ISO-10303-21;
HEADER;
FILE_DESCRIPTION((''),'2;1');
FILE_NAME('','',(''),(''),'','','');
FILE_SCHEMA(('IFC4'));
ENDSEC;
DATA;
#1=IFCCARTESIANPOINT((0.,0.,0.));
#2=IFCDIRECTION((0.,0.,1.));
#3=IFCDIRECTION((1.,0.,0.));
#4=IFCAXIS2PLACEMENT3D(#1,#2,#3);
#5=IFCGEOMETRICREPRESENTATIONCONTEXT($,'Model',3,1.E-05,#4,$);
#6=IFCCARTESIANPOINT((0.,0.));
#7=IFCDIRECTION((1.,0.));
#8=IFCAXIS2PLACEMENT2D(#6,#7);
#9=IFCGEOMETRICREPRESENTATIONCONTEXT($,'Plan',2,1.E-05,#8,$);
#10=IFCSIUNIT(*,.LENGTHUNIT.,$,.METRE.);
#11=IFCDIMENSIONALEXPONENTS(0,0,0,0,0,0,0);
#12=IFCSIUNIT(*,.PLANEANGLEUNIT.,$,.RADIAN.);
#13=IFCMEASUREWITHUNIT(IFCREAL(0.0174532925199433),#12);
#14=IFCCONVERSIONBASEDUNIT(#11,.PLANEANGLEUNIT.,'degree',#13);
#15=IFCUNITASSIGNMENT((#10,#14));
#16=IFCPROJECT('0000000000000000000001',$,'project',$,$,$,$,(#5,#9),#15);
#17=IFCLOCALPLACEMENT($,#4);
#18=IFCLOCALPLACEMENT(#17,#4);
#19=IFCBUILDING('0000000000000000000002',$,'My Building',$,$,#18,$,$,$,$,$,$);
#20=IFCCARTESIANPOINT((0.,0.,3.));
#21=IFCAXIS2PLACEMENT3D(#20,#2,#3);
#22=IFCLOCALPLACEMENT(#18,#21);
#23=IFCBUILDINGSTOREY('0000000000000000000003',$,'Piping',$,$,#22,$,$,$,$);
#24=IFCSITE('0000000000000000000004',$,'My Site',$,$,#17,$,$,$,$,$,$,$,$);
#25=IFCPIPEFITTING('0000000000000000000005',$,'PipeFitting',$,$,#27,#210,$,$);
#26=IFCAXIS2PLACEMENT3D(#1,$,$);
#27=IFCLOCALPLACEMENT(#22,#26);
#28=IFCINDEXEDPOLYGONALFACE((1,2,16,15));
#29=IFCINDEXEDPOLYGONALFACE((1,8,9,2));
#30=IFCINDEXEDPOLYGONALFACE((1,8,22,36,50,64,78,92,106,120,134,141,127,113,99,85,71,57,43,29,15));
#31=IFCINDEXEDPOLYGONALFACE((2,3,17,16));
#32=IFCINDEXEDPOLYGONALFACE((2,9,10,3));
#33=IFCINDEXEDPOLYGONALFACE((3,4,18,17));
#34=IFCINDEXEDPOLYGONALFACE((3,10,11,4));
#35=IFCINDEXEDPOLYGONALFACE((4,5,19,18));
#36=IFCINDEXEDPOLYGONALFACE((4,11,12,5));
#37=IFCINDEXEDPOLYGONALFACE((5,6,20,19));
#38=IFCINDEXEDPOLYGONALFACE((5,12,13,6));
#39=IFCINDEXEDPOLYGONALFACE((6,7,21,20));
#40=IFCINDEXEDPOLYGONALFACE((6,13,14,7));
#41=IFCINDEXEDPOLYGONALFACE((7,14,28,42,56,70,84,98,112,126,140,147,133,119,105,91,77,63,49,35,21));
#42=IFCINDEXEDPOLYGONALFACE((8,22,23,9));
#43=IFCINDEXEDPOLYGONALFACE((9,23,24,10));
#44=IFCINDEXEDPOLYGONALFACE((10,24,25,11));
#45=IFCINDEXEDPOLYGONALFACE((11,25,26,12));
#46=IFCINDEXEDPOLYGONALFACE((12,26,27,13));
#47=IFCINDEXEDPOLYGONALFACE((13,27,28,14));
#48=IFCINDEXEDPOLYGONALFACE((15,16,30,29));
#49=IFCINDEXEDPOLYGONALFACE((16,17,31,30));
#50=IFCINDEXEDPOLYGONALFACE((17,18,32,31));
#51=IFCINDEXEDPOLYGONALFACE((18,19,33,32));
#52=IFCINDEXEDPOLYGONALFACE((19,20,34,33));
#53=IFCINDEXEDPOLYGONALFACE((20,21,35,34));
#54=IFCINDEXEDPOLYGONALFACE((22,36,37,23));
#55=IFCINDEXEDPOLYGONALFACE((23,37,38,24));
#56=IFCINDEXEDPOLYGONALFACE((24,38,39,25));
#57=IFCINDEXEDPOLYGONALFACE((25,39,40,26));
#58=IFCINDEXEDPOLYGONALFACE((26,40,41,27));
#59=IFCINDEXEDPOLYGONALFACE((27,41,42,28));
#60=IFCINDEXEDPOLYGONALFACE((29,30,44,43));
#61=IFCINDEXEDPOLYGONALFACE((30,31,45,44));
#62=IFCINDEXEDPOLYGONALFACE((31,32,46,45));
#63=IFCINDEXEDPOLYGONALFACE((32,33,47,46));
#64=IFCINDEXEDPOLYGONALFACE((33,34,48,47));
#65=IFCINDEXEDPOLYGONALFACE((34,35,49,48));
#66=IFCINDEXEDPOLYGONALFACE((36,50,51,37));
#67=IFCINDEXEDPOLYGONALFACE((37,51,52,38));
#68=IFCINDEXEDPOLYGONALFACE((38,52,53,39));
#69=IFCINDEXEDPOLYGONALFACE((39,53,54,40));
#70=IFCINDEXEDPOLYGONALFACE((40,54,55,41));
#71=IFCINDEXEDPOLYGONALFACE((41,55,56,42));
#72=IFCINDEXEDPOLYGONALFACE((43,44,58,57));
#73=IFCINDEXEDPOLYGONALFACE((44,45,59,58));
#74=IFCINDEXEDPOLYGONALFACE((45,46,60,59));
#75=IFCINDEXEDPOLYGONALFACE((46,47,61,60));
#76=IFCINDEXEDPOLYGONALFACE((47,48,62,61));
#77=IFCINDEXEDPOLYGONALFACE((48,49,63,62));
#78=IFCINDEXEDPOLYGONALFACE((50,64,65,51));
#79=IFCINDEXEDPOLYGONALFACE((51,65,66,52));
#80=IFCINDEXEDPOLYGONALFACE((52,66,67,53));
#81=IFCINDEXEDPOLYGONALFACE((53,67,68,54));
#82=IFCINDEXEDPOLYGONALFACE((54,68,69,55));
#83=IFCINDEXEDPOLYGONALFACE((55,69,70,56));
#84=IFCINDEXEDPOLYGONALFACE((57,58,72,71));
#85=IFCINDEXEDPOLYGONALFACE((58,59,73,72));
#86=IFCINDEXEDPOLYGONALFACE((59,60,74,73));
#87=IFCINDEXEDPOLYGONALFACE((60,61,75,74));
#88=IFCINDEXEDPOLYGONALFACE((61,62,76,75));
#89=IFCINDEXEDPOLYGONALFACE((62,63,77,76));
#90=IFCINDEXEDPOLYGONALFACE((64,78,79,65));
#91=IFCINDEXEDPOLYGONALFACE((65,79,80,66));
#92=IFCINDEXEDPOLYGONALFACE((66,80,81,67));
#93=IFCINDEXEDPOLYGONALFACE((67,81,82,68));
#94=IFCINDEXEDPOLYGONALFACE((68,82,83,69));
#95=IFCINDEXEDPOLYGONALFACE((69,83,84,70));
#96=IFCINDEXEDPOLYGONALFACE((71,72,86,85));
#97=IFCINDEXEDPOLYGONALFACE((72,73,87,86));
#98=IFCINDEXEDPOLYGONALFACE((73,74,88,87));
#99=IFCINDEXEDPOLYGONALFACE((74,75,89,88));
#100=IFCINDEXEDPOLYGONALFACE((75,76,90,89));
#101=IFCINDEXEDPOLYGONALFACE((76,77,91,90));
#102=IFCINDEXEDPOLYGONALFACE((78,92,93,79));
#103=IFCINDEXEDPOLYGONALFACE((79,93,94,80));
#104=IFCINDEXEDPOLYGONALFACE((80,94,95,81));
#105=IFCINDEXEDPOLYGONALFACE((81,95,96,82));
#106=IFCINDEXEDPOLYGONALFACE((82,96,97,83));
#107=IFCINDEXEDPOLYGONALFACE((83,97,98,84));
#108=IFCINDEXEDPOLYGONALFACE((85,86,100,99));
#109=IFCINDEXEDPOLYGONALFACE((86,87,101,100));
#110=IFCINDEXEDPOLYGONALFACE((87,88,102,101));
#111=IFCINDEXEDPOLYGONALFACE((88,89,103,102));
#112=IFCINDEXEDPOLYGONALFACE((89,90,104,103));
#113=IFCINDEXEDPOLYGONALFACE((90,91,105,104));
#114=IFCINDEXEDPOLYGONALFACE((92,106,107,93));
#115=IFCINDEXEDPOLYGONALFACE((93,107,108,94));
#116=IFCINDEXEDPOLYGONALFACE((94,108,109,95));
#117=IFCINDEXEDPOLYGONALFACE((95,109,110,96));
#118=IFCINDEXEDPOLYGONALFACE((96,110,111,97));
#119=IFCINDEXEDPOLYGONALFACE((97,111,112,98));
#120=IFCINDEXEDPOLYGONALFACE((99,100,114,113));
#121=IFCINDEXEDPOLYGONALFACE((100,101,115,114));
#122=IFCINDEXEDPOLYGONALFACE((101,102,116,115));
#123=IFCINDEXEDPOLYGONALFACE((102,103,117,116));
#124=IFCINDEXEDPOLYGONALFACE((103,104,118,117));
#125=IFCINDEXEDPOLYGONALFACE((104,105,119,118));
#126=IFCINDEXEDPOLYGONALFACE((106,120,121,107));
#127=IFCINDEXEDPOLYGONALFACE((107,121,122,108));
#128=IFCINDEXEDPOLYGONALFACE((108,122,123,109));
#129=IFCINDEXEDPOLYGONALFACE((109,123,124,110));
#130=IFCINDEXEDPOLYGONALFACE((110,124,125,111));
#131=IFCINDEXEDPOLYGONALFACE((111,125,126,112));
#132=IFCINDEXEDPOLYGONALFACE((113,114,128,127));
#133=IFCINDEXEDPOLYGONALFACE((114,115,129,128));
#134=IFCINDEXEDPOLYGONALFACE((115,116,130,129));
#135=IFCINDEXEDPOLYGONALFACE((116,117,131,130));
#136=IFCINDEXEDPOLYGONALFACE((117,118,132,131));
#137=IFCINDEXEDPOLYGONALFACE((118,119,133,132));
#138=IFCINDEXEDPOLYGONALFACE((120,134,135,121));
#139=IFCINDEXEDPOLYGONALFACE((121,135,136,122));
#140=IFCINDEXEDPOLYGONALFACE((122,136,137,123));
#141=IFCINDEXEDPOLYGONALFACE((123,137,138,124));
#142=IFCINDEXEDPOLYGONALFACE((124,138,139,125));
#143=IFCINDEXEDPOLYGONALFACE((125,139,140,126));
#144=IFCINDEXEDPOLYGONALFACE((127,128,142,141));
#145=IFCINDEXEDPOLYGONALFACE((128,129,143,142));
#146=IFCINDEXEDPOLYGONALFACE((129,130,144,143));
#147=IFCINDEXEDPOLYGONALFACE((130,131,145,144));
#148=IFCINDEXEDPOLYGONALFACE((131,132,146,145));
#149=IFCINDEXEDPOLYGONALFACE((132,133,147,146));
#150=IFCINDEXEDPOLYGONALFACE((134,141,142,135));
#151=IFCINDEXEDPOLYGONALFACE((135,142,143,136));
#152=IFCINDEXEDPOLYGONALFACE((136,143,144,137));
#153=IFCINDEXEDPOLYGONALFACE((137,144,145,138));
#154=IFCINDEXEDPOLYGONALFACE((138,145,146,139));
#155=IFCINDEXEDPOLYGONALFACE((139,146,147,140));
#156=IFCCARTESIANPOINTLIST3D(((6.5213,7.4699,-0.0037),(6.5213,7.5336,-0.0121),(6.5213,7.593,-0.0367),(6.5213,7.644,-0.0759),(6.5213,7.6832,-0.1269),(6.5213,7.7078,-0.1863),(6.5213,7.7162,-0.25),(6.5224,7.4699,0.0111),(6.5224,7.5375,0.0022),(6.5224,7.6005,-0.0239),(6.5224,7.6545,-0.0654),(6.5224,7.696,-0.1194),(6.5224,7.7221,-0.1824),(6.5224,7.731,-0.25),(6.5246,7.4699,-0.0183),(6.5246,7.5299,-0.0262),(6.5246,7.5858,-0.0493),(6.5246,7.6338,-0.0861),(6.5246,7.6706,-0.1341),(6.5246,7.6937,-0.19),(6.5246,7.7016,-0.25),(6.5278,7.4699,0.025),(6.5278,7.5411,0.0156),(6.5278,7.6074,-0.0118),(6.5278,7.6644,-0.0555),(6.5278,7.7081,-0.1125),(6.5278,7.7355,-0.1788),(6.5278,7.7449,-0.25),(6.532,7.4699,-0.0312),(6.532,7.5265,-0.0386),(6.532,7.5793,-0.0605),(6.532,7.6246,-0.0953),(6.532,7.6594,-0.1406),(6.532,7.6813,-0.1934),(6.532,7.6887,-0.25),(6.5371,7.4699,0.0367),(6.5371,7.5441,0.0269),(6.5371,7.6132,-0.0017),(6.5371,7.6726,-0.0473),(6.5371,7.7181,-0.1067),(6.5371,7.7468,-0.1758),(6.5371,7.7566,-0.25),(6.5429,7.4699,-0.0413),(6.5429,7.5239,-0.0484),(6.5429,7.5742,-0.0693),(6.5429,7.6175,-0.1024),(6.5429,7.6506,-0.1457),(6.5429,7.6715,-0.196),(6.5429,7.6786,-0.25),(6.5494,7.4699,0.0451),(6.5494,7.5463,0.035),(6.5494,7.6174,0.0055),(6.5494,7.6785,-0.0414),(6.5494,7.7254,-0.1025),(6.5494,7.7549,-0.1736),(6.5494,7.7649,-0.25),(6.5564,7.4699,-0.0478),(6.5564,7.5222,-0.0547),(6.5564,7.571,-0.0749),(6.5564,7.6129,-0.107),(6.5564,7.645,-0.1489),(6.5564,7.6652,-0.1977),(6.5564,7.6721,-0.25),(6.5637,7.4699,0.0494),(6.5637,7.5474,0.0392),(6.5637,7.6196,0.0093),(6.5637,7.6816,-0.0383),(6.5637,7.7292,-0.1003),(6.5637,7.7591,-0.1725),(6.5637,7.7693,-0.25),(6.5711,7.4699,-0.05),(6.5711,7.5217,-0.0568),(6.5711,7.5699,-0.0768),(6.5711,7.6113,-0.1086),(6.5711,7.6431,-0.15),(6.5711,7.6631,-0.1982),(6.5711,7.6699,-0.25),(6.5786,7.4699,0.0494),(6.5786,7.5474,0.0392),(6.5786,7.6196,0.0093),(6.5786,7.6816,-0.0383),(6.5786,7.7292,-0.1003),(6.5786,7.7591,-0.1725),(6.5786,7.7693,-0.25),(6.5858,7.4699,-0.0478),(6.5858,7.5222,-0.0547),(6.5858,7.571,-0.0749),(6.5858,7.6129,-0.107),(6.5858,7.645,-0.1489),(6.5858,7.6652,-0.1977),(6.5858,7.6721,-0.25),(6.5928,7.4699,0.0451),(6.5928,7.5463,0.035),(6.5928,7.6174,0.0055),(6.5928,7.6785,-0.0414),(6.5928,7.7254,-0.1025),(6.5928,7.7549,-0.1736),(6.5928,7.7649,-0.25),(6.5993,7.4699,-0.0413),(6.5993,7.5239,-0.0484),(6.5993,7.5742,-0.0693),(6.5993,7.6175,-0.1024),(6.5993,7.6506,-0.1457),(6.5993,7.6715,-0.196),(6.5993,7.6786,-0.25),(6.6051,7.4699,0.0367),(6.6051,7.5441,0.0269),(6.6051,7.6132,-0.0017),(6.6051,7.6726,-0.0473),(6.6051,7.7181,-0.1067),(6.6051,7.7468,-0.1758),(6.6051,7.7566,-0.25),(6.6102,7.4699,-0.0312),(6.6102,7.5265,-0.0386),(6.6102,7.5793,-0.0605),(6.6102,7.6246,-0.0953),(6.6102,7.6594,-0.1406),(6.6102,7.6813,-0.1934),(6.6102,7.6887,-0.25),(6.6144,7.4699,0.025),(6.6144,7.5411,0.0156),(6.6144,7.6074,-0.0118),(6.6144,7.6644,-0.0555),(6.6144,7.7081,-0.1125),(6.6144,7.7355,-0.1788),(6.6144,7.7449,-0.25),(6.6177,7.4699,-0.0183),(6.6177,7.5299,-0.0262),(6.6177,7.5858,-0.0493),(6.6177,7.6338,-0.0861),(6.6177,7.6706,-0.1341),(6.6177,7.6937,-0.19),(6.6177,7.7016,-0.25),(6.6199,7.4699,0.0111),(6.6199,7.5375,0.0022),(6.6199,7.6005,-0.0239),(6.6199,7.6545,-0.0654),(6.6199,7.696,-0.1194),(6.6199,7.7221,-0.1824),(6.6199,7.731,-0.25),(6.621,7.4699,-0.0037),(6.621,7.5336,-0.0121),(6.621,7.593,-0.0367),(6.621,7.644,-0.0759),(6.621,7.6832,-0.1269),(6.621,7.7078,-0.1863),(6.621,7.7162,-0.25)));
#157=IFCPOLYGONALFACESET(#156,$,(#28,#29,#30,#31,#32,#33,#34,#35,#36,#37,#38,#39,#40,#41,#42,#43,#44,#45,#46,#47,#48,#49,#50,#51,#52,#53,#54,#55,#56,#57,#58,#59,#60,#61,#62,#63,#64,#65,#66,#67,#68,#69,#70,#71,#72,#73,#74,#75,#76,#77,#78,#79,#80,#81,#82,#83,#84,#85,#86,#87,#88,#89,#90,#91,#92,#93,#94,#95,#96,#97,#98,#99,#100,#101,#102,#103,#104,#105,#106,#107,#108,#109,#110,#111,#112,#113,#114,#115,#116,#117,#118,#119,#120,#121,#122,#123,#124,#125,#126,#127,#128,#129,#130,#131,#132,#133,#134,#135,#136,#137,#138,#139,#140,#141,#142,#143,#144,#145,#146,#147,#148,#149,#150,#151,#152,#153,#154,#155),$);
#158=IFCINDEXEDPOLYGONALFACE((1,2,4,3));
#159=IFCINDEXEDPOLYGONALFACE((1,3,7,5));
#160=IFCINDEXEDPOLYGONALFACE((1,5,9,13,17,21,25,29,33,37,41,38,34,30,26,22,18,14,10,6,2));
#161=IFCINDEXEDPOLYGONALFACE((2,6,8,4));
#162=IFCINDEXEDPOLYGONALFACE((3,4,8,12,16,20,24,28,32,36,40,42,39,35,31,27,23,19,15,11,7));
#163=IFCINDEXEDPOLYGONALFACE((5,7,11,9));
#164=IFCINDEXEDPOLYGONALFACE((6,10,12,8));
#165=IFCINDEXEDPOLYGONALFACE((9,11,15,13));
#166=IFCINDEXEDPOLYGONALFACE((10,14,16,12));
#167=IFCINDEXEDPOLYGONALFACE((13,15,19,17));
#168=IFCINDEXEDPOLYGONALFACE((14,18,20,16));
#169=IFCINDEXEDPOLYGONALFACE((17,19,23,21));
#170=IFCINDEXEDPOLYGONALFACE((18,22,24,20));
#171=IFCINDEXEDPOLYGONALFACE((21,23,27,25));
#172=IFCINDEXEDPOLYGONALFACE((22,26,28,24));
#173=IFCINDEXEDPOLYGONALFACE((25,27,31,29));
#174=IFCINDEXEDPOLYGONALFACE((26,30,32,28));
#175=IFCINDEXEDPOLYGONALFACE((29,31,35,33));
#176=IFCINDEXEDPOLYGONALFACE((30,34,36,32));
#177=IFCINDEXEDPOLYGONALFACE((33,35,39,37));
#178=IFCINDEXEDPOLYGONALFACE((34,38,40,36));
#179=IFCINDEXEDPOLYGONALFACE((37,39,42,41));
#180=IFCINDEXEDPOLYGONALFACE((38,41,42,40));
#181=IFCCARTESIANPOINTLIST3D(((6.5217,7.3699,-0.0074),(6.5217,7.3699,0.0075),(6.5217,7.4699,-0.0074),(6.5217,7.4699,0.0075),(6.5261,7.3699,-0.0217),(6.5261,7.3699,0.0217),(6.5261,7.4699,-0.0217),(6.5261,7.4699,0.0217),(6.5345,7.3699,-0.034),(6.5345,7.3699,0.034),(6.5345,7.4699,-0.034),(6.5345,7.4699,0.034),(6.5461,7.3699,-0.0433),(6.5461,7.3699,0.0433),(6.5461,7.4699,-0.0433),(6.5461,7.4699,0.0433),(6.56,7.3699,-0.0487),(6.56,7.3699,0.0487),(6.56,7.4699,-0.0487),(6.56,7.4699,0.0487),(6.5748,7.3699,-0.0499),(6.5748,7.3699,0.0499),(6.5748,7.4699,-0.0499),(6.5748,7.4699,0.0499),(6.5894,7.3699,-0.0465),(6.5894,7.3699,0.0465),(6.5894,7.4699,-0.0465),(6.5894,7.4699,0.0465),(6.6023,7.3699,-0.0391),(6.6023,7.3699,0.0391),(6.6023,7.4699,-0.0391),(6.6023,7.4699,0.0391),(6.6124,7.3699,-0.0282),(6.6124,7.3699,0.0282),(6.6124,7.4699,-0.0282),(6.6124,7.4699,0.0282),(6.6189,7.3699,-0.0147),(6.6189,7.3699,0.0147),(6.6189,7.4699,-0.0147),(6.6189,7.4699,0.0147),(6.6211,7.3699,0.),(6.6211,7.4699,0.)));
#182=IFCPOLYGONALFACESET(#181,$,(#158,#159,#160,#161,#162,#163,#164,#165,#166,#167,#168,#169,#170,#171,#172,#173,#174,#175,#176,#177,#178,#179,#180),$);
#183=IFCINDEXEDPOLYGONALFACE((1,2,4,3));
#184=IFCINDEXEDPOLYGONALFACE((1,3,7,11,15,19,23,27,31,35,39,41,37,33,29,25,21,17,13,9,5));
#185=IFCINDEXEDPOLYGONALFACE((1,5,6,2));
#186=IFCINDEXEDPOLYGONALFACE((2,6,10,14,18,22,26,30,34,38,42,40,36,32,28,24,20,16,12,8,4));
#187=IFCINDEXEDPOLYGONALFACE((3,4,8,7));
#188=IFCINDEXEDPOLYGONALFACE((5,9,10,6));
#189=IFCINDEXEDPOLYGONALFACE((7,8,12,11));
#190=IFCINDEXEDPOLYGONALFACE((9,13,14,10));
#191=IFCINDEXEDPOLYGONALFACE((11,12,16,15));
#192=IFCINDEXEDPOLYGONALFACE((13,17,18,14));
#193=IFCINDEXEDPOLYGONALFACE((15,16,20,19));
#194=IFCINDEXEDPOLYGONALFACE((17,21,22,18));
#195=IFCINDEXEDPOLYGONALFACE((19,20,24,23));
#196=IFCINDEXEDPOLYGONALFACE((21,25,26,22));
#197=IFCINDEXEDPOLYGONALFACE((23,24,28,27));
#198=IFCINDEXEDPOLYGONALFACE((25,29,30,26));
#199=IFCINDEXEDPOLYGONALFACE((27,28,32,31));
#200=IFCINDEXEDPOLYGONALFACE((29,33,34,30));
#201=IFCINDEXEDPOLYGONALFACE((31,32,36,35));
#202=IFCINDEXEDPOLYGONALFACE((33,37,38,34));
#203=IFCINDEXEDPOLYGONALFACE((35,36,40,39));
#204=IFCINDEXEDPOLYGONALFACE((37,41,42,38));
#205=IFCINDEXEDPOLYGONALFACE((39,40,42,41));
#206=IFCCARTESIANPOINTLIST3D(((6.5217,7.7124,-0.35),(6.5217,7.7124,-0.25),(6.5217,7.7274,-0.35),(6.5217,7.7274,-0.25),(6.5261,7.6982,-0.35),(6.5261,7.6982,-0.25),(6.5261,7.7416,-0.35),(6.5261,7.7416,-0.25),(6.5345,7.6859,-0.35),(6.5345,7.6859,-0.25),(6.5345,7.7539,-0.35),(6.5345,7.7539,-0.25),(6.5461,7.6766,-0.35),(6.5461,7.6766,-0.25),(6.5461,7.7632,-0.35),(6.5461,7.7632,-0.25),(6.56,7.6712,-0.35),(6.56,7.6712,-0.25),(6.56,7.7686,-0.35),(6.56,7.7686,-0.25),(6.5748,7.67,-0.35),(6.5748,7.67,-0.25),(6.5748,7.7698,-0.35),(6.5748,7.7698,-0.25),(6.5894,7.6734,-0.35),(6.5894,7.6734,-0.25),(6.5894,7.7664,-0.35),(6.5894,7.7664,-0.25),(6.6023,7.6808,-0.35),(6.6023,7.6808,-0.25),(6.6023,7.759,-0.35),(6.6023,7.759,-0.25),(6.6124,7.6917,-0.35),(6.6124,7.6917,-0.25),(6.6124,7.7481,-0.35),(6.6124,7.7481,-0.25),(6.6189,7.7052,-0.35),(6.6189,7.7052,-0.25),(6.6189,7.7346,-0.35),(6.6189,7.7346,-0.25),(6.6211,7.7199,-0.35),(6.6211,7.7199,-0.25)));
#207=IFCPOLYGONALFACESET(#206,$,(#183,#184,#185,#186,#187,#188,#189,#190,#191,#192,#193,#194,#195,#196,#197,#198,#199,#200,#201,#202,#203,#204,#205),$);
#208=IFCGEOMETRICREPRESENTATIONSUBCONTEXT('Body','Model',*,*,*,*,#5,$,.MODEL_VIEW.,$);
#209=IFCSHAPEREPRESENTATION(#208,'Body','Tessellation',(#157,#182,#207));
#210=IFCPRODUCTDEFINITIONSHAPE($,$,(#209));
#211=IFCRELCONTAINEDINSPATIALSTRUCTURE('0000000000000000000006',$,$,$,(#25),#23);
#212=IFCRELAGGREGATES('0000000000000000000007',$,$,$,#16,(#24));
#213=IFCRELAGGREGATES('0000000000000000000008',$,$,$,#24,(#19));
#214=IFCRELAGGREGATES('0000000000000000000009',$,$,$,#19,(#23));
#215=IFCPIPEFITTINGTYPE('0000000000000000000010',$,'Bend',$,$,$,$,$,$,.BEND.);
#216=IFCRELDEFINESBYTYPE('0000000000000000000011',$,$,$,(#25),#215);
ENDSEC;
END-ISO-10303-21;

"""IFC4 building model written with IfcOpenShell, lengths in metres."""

from ifc_helpers import new_model, entity, si_unit, converted_unit, frame, origin_with_axes, origin_2d_with_axis, place, context, subcontext, project, spatial, circle, extrude, source, transform, mapped, type_object, type_shapes, element, save


model = new_model("IFC4")

# Units and contexts
model_context = context("Model", 3, precision=1e-05, world=origin_with_axes())
plan_context = context("Plan", 2, precision=1e-05, world=origin_2d_with_axis())
body_context = subcontext(model_context, "Body", "Model", "MODEL_VIEW")
ifc_project = project(units=[si_unit("LENGTHUNIT", "METRE"), converted_unit("PLANEANGLEUNIT", "degree", entity("IfcReal", 0.0174532925199433), si_unit("PLANEANGLEUNIT", "RADIAN"), dimensions=[0, 0, 0, 0, 0, 0, 0])], contexts=[model_context, plan_context])

# Site, building, storey
site_placement = place(None, origin_with_axes())
site = spatial("IfcSite", under=ifc_project, at=site_placement, Name="My Site")
building_placement = place(site_placement, origin_with_axes())
building = spatial("IfcBuilding", under=site, at=building_placement, Name="My Building")
storey_placement = place(building_placement, frame((0.0, 0.0, 3.0), z_axis=(0.0, 0.0, 1.0), x_axis=(1.0, 0.0, 0.0)))
storey = spatial("IfcBuildingStorey", under=building, at=storey_placement, Name="Piping")

# Pipe fitting
pipe_fitting_type = type_object("IfcPipeFittingType", Name="Bend", PredefinedType="BEND")
shared_shape = source(origin_with_axes(), body_context, "Body", "SolidModel", [
    entity("IfcSweptDiskSolid", entity("IfcIndexedPolyCurve", entity("IfcCartesianPointList3D", [[0.0, 0.0, -0.1], [0.0, -0.0732, -0.2768], [0.0, -0.25, -0.35]]), [entity("IfcArcIndex", [1, 2, 3])]), 0.05),
    extrude(circle(Radius=0.05), origin_with_axes(), (0.0, 0.0, -1.0), 0.1),
    extrude(circle(Radius=0.05), frame((0.0, -0.25, -0.35), z_axis=(0.0, -1.0, 0.0), x_axis=(1.0, 0.0, 0.0)), (0.0, 0.0, 1.0), 0.1),
])
type_shapes(pipe_fitting_type, [shared_shape])
for number, where, z_axis, x_axis, name in (
    (1, (6.5711, 7.3699, 0.0), (0.0, -1.0, 0.0), (1.0, 0.0, 0.0), "PipeFitting"),
):
    element("IfcPipeFitting", number, at=place(storey_placement, frame(where, z_axis=z_axis, x_axis=x_axis)), inside=storey, type_object=pipe_fitting_type, Name=name, context=body_context, shape_type="MappedRepresentation", body=[
        mapped(shared_shape, transform((0.0, 0.0, 0.0), x_axis=(1.0, 0.0, 0.0), y_axis=(0.0, 1.0, 0.0), z_axis=(0.0, 0.0, 1.0), scale=1.0)),
    ])

save(model, "model.ifc")
